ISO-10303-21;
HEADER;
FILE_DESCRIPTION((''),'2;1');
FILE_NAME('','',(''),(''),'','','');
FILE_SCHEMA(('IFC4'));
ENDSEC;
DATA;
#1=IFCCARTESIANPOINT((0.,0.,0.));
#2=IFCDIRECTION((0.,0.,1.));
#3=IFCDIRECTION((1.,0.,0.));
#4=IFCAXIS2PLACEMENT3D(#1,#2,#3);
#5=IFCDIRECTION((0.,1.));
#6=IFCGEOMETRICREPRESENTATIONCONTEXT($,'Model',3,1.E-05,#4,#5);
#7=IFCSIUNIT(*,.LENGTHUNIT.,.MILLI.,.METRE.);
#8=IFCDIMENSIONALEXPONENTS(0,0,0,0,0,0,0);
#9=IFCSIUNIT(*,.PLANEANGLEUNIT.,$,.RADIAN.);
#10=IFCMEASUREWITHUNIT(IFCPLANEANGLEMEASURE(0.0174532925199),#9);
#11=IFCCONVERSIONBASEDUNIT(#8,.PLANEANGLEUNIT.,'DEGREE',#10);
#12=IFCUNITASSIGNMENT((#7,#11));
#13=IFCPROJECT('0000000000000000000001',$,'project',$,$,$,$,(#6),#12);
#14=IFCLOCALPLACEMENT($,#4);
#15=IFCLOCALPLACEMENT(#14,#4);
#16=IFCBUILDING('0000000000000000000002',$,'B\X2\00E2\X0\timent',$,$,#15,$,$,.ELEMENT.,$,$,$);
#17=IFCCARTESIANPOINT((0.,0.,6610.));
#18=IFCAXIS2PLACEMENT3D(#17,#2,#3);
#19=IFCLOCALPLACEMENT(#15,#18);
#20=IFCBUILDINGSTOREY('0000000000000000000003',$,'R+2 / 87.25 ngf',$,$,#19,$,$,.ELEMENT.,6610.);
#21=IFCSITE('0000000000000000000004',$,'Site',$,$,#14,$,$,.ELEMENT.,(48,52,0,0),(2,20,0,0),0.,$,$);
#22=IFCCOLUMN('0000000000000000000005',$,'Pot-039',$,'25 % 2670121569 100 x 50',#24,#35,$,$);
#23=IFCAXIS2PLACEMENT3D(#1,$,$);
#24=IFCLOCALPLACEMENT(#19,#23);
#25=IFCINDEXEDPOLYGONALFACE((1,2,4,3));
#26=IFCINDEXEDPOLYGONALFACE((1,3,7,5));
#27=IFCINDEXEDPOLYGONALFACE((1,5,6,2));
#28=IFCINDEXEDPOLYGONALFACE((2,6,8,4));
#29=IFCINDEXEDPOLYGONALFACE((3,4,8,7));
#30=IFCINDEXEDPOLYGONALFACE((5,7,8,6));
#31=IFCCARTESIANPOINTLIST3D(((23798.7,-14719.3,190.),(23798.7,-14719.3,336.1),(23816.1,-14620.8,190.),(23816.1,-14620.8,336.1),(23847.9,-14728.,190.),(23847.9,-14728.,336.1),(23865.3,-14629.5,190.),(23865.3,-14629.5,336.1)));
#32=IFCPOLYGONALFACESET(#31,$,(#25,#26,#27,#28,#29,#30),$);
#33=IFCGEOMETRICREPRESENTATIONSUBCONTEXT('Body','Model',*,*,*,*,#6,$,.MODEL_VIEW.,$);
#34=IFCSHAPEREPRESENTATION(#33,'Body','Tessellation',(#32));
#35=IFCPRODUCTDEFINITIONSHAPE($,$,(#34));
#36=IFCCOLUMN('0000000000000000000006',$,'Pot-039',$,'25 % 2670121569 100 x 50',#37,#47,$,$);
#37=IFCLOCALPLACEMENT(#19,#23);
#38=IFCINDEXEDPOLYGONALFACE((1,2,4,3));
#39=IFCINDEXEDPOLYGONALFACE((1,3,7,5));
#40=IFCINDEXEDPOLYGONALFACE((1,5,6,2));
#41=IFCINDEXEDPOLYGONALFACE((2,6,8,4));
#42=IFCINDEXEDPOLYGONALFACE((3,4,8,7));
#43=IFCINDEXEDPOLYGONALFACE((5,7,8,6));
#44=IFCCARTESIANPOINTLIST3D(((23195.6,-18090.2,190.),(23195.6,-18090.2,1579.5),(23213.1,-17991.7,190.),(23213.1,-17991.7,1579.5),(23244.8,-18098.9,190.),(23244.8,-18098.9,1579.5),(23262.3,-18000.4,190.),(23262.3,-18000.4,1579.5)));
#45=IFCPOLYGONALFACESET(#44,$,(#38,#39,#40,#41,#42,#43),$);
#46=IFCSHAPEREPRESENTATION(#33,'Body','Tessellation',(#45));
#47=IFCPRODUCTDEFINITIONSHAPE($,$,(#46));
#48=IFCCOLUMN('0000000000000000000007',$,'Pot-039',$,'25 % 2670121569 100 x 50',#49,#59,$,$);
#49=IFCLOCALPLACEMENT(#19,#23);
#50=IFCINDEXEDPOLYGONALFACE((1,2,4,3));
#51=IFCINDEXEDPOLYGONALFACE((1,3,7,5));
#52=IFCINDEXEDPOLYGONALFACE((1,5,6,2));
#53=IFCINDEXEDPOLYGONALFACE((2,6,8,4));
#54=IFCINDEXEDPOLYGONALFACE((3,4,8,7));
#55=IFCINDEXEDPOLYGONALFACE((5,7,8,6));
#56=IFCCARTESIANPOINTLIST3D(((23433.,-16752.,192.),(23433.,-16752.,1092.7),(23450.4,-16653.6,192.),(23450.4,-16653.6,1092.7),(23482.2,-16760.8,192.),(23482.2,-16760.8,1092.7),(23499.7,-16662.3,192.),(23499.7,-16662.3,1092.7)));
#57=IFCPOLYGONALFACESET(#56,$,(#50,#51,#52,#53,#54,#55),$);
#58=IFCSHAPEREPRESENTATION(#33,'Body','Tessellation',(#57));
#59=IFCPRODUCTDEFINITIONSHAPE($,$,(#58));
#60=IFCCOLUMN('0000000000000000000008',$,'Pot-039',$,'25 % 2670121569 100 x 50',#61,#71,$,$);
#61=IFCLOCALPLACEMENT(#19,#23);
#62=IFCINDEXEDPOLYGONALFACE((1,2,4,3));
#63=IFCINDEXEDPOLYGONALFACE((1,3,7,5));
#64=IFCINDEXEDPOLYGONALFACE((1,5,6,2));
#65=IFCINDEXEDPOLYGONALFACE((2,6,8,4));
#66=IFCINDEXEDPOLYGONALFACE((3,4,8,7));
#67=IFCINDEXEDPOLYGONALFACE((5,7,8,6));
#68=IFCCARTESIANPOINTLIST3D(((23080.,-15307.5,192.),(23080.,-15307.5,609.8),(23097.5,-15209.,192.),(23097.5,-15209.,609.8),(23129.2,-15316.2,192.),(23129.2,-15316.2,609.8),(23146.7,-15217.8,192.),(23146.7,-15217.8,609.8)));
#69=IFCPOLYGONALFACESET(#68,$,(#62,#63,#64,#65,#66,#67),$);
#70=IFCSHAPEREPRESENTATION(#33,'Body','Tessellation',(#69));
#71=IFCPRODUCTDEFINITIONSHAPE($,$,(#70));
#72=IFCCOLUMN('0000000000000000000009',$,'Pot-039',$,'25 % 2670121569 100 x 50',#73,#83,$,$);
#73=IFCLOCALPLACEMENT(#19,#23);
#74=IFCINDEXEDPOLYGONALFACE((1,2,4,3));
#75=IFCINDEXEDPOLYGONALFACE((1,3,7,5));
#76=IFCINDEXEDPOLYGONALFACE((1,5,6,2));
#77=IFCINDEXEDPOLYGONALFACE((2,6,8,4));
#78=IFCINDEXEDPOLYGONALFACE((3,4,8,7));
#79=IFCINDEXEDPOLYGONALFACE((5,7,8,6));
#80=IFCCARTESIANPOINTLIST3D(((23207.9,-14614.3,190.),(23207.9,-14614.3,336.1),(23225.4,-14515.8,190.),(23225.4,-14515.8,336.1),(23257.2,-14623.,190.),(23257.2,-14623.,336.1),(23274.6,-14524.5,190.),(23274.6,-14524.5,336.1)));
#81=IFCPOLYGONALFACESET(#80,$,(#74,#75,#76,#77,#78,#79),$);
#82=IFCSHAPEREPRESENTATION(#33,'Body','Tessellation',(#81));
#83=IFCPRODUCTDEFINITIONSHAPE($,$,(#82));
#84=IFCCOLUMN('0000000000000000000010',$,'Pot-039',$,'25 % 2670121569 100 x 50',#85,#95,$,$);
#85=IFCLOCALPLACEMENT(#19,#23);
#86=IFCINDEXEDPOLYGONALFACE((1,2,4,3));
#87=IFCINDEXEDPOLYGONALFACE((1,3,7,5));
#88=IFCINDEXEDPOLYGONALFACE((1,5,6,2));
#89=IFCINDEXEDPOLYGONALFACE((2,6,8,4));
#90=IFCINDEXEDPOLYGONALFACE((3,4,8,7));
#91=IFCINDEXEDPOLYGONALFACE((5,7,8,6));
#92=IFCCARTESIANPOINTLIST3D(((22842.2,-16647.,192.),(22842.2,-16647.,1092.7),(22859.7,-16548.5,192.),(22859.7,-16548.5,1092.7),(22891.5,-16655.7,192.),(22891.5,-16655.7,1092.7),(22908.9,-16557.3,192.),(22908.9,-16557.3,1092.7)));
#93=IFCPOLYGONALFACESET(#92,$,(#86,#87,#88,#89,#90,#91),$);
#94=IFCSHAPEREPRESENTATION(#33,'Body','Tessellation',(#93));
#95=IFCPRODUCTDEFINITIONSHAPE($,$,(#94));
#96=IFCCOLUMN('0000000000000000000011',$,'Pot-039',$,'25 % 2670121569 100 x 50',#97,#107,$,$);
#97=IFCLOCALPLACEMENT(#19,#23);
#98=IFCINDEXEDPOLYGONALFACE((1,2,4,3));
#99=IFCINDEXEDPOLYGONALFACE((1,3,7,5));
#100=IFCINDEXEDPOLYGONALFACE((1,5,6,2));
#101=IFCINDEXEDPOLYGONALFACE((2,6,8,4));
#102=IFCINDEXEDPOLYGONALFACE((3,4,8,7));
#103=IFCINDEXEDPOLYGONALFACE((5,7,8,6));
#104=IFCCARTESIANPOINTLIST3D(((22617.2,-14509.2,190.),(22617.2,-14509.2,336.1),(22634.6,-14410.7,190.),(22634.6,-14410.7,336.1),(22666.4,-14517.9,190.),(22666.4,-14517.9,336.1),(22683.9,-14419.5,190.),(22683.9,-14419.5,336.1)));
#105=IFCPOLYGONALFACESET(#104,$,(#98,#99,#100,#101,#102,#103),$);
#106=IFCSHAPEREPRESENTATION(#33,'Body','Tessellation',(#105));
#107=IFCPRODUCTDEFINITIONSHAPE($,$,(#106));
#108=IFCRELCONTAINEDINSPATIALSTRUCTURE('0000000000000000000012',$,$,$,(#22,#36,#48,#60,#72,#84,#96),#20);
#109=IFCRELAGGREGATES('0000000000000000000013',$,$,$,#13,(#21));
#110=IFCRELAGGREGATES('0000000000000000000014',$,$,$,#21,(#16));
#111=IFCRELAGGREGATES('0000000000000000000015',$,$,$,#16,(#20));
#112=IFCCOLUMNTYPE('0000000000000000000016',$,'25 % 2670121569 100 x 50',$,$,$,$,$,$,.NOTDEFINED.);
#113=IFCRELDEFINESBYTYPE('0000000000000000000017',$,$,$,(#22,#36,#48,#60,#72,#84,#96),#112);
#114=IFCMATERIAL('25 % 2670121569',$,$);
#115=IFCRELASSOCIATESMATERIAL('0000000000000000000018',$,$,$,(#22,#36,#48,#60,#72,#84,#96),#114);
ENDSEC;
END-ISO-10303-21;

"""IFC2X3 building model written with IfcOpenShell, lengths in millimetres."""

from ifc_helpers import new_model, entity, si_unit, converted_unit, direction, frame, origin_with_axes, origin_2d_with_axis, place, context, subcontext, project, spatial, rectangle, extrude, material, type_object, element, save


model = new_model("IFC2X3")

# Units and contexts
model_context = context("Model", 3, precision=1e-05, world=origin_with_axes(), true_north=direction((0.0, 1.0)))
body_context = subcontext(model_context, "Body", "Model", "MODEL_VIEW")
ifc_project = project(units=[si_unit("LENGTHUNIT", "METRE", prefix="MILLI"), converted_unit("PLANEANGLEUNIT", "DEGREE", entity("IfcPlaneAngleMeasure", 0.0174532925199), si_unit("PLANEANGLEUNIT", "RADIAN"), dimensions=[0, 0, 0, 0, 0, 0, 0])], contexts=[model_context])

# Site, building, storey
site_placement = place(None, origin_with_axes())
site = spatial("IfcSite", under=ifc_project, at=site_placement, Name="Site", CompositionType="ELEMENT", RefLatitude=(48, 52, 0, 0), RefLongitude=(2, 20, 0, 0), RefElevation=0.0)
building_placement = place(site_placement, origin_with_axes())
building = spatial("IfcBuilding", under=site, at=building_placement, Name="Bâtiment", CompositionType="ELEMENT")
storey_placement = place(building_placement, frame((0.0, 0.0, 6610.0), z_axis=(0.0, 0.0, 1.0), x_axis=(1.0, 0.0, 0.0)))
storey = spatial("IfcBuildingStorey", under=building, at=storey_placement, Name="R+2 / 87.25 ngf", CompositionType="ELEMENT", Elevation=6610.0)

# Columns
ifc_material = material(Name="25 % 2670121569")
column_type = type_object("IfcColumnType", Name="25 % 2670121569 100 x 50", PredefinedType="NOTDEFINED")
column_1_placement = place(storey_placement, frame((23832.0, -14674.4, 190.0), z_axis=(0.0, 0.0, 1.0), x_axis=(0.174407, 0.984674, 0.0)))
element("IfcColumn", 1, at=column_1_placement, inside=storey, type_object=column_type, material=ifc_material, Name="Pot-039", ObjectType="25 % 2670121569 100 x 50", context=body_context, shape_type="SweptSolid", body=[
    extrude(rectangle(XDim=100.0, YDim=50.0, at=origin_2d_with_axis()), origin_with_axes(), (0.0, 0.0, 1.0), 146.1),
])
column_2_placement = place(storey_placement, frame((23228.9, -18045.3, 190.0), z_axis=(0.0, 0.0, 1.0), x_axis=(0.17478, 0.984607, 0.0)))
element("IfcColumn", 2, at=column_2_placement, inside=storey, type_object=column_type, material=ifc_material, Name="Pot-039", ObjectType="25 % 2670121569 100 x 50", context=body_context, shape_type="SweptSolid", body=[
    extrude(rectangle(XDim=100.0, YDim=50.0, at=origin_2d_with_axis()), origin_with_axes(), (0.0, 0.0, 1.0), 1389.5),
])
column_3_placement = place(storey_placement, frame((23466.3, -16707.2, 192.0), z_axis=(0.0, 0.0, 1.0), x_axis=(0.17478, 0.984607, 0.0)))
element("IfcColumn", 3, at=column_3_placement, inside=storey, type_object=column_type, material=ifc_material, Name="Pot-039", ObjectType="25 % 2670121569 100 x 50", context=body_context, shape_type="SweptSolid", body=[
    extrude(rectangle(XDim=100.0, YDim=50.0, at=origin_2d_with_axis()), origin_with_axes(), (0.0, 0.0, 1.0), 900.7),
])
column_4_placement = place(storey_placement, frame((23113.3, -15262.6, 192.0), z_axis=(0.0, 0.0, 1.0), x_axis=(0.17478, 0.984607, 0.0)))
element("IfcColumn", 4, at=column_4_placement, inside=storey, type_object=column_type, material=ifc_material, Name="Pot-039", ObjectType="25 % 2670121569 100 x 50", context=body_context, shape_type="SweptSolid", body=[
    extrude(rectangle(XDim=100.0, YDim=50.0, at=origin_2d_with_axis()), origin_with_axes(), (0.0, 0.0, 1.0), 417.8),
])
column_5_placement = place(storey_placement, frame((23241.3, -14569.4, 190.0), z_axis=(0.0, 0.0, 1.0), x_axis=(0.174407, 0.984674, 0.0)))
element("IfcColumn", 5, at=column_5_placement, inside=storey, type_object=column_type, material=ifc_material, Name="Pot-039", ObjectType="25 % 2670121569 100 x 50", context=body_context, shape_type="SweptSolid", body=[
    extrude(rectangle(XDim=100.0, YDim=50.0, at=origin_2d_with_axis()), origin_with_axes(), (0.0, 0.0, 1.0), 146.1),
])
column_6_placement = place(storey_placement, frame((22875.6, -16602.1, 192.0), z_axis=(0.0, 0.0, 1.0), x_axis=(0.17478, 0.984607, 0.0)))
element("IfcColumn", 6, at=column_6_placement, inside=storey, type_object=column_type, material=ifc_material, Name="Pot-039", ObjectType="25 % 2670121569 100 x 50", context=body_context, shape_type="SweptSolid", body=[
    extrude(rectangle(XDim=100.0, YDim=50.0, at=origin_2d_with_axis()), origin_with_axes(), (0.0, 0.0, 1.0), 900.7),
])
column_7_placement = place(storey_placement, frame((22650.5, -14464.3, 190.0), z_axis=(0.0, 0.0, 1.0), x_axis=(0.174407, 0.984674, 0.0)))
element("IfcColumn", 7, at=column_7_placement, inside=storey, type_object=column_type, material=ifc_material, Name="Pot-039", ObjectType="25 % 2670121569 100 x 50", context=body_context, shape_type="SweptSolid", body=[
    extrude(rectangle(XDim=100.0, YDim=50.0, at=origin_2d_with_axis()), origin_with_axes(), (0.0, 0.0, 1.0), 146.1),
])

save(model, "model.ifc")
